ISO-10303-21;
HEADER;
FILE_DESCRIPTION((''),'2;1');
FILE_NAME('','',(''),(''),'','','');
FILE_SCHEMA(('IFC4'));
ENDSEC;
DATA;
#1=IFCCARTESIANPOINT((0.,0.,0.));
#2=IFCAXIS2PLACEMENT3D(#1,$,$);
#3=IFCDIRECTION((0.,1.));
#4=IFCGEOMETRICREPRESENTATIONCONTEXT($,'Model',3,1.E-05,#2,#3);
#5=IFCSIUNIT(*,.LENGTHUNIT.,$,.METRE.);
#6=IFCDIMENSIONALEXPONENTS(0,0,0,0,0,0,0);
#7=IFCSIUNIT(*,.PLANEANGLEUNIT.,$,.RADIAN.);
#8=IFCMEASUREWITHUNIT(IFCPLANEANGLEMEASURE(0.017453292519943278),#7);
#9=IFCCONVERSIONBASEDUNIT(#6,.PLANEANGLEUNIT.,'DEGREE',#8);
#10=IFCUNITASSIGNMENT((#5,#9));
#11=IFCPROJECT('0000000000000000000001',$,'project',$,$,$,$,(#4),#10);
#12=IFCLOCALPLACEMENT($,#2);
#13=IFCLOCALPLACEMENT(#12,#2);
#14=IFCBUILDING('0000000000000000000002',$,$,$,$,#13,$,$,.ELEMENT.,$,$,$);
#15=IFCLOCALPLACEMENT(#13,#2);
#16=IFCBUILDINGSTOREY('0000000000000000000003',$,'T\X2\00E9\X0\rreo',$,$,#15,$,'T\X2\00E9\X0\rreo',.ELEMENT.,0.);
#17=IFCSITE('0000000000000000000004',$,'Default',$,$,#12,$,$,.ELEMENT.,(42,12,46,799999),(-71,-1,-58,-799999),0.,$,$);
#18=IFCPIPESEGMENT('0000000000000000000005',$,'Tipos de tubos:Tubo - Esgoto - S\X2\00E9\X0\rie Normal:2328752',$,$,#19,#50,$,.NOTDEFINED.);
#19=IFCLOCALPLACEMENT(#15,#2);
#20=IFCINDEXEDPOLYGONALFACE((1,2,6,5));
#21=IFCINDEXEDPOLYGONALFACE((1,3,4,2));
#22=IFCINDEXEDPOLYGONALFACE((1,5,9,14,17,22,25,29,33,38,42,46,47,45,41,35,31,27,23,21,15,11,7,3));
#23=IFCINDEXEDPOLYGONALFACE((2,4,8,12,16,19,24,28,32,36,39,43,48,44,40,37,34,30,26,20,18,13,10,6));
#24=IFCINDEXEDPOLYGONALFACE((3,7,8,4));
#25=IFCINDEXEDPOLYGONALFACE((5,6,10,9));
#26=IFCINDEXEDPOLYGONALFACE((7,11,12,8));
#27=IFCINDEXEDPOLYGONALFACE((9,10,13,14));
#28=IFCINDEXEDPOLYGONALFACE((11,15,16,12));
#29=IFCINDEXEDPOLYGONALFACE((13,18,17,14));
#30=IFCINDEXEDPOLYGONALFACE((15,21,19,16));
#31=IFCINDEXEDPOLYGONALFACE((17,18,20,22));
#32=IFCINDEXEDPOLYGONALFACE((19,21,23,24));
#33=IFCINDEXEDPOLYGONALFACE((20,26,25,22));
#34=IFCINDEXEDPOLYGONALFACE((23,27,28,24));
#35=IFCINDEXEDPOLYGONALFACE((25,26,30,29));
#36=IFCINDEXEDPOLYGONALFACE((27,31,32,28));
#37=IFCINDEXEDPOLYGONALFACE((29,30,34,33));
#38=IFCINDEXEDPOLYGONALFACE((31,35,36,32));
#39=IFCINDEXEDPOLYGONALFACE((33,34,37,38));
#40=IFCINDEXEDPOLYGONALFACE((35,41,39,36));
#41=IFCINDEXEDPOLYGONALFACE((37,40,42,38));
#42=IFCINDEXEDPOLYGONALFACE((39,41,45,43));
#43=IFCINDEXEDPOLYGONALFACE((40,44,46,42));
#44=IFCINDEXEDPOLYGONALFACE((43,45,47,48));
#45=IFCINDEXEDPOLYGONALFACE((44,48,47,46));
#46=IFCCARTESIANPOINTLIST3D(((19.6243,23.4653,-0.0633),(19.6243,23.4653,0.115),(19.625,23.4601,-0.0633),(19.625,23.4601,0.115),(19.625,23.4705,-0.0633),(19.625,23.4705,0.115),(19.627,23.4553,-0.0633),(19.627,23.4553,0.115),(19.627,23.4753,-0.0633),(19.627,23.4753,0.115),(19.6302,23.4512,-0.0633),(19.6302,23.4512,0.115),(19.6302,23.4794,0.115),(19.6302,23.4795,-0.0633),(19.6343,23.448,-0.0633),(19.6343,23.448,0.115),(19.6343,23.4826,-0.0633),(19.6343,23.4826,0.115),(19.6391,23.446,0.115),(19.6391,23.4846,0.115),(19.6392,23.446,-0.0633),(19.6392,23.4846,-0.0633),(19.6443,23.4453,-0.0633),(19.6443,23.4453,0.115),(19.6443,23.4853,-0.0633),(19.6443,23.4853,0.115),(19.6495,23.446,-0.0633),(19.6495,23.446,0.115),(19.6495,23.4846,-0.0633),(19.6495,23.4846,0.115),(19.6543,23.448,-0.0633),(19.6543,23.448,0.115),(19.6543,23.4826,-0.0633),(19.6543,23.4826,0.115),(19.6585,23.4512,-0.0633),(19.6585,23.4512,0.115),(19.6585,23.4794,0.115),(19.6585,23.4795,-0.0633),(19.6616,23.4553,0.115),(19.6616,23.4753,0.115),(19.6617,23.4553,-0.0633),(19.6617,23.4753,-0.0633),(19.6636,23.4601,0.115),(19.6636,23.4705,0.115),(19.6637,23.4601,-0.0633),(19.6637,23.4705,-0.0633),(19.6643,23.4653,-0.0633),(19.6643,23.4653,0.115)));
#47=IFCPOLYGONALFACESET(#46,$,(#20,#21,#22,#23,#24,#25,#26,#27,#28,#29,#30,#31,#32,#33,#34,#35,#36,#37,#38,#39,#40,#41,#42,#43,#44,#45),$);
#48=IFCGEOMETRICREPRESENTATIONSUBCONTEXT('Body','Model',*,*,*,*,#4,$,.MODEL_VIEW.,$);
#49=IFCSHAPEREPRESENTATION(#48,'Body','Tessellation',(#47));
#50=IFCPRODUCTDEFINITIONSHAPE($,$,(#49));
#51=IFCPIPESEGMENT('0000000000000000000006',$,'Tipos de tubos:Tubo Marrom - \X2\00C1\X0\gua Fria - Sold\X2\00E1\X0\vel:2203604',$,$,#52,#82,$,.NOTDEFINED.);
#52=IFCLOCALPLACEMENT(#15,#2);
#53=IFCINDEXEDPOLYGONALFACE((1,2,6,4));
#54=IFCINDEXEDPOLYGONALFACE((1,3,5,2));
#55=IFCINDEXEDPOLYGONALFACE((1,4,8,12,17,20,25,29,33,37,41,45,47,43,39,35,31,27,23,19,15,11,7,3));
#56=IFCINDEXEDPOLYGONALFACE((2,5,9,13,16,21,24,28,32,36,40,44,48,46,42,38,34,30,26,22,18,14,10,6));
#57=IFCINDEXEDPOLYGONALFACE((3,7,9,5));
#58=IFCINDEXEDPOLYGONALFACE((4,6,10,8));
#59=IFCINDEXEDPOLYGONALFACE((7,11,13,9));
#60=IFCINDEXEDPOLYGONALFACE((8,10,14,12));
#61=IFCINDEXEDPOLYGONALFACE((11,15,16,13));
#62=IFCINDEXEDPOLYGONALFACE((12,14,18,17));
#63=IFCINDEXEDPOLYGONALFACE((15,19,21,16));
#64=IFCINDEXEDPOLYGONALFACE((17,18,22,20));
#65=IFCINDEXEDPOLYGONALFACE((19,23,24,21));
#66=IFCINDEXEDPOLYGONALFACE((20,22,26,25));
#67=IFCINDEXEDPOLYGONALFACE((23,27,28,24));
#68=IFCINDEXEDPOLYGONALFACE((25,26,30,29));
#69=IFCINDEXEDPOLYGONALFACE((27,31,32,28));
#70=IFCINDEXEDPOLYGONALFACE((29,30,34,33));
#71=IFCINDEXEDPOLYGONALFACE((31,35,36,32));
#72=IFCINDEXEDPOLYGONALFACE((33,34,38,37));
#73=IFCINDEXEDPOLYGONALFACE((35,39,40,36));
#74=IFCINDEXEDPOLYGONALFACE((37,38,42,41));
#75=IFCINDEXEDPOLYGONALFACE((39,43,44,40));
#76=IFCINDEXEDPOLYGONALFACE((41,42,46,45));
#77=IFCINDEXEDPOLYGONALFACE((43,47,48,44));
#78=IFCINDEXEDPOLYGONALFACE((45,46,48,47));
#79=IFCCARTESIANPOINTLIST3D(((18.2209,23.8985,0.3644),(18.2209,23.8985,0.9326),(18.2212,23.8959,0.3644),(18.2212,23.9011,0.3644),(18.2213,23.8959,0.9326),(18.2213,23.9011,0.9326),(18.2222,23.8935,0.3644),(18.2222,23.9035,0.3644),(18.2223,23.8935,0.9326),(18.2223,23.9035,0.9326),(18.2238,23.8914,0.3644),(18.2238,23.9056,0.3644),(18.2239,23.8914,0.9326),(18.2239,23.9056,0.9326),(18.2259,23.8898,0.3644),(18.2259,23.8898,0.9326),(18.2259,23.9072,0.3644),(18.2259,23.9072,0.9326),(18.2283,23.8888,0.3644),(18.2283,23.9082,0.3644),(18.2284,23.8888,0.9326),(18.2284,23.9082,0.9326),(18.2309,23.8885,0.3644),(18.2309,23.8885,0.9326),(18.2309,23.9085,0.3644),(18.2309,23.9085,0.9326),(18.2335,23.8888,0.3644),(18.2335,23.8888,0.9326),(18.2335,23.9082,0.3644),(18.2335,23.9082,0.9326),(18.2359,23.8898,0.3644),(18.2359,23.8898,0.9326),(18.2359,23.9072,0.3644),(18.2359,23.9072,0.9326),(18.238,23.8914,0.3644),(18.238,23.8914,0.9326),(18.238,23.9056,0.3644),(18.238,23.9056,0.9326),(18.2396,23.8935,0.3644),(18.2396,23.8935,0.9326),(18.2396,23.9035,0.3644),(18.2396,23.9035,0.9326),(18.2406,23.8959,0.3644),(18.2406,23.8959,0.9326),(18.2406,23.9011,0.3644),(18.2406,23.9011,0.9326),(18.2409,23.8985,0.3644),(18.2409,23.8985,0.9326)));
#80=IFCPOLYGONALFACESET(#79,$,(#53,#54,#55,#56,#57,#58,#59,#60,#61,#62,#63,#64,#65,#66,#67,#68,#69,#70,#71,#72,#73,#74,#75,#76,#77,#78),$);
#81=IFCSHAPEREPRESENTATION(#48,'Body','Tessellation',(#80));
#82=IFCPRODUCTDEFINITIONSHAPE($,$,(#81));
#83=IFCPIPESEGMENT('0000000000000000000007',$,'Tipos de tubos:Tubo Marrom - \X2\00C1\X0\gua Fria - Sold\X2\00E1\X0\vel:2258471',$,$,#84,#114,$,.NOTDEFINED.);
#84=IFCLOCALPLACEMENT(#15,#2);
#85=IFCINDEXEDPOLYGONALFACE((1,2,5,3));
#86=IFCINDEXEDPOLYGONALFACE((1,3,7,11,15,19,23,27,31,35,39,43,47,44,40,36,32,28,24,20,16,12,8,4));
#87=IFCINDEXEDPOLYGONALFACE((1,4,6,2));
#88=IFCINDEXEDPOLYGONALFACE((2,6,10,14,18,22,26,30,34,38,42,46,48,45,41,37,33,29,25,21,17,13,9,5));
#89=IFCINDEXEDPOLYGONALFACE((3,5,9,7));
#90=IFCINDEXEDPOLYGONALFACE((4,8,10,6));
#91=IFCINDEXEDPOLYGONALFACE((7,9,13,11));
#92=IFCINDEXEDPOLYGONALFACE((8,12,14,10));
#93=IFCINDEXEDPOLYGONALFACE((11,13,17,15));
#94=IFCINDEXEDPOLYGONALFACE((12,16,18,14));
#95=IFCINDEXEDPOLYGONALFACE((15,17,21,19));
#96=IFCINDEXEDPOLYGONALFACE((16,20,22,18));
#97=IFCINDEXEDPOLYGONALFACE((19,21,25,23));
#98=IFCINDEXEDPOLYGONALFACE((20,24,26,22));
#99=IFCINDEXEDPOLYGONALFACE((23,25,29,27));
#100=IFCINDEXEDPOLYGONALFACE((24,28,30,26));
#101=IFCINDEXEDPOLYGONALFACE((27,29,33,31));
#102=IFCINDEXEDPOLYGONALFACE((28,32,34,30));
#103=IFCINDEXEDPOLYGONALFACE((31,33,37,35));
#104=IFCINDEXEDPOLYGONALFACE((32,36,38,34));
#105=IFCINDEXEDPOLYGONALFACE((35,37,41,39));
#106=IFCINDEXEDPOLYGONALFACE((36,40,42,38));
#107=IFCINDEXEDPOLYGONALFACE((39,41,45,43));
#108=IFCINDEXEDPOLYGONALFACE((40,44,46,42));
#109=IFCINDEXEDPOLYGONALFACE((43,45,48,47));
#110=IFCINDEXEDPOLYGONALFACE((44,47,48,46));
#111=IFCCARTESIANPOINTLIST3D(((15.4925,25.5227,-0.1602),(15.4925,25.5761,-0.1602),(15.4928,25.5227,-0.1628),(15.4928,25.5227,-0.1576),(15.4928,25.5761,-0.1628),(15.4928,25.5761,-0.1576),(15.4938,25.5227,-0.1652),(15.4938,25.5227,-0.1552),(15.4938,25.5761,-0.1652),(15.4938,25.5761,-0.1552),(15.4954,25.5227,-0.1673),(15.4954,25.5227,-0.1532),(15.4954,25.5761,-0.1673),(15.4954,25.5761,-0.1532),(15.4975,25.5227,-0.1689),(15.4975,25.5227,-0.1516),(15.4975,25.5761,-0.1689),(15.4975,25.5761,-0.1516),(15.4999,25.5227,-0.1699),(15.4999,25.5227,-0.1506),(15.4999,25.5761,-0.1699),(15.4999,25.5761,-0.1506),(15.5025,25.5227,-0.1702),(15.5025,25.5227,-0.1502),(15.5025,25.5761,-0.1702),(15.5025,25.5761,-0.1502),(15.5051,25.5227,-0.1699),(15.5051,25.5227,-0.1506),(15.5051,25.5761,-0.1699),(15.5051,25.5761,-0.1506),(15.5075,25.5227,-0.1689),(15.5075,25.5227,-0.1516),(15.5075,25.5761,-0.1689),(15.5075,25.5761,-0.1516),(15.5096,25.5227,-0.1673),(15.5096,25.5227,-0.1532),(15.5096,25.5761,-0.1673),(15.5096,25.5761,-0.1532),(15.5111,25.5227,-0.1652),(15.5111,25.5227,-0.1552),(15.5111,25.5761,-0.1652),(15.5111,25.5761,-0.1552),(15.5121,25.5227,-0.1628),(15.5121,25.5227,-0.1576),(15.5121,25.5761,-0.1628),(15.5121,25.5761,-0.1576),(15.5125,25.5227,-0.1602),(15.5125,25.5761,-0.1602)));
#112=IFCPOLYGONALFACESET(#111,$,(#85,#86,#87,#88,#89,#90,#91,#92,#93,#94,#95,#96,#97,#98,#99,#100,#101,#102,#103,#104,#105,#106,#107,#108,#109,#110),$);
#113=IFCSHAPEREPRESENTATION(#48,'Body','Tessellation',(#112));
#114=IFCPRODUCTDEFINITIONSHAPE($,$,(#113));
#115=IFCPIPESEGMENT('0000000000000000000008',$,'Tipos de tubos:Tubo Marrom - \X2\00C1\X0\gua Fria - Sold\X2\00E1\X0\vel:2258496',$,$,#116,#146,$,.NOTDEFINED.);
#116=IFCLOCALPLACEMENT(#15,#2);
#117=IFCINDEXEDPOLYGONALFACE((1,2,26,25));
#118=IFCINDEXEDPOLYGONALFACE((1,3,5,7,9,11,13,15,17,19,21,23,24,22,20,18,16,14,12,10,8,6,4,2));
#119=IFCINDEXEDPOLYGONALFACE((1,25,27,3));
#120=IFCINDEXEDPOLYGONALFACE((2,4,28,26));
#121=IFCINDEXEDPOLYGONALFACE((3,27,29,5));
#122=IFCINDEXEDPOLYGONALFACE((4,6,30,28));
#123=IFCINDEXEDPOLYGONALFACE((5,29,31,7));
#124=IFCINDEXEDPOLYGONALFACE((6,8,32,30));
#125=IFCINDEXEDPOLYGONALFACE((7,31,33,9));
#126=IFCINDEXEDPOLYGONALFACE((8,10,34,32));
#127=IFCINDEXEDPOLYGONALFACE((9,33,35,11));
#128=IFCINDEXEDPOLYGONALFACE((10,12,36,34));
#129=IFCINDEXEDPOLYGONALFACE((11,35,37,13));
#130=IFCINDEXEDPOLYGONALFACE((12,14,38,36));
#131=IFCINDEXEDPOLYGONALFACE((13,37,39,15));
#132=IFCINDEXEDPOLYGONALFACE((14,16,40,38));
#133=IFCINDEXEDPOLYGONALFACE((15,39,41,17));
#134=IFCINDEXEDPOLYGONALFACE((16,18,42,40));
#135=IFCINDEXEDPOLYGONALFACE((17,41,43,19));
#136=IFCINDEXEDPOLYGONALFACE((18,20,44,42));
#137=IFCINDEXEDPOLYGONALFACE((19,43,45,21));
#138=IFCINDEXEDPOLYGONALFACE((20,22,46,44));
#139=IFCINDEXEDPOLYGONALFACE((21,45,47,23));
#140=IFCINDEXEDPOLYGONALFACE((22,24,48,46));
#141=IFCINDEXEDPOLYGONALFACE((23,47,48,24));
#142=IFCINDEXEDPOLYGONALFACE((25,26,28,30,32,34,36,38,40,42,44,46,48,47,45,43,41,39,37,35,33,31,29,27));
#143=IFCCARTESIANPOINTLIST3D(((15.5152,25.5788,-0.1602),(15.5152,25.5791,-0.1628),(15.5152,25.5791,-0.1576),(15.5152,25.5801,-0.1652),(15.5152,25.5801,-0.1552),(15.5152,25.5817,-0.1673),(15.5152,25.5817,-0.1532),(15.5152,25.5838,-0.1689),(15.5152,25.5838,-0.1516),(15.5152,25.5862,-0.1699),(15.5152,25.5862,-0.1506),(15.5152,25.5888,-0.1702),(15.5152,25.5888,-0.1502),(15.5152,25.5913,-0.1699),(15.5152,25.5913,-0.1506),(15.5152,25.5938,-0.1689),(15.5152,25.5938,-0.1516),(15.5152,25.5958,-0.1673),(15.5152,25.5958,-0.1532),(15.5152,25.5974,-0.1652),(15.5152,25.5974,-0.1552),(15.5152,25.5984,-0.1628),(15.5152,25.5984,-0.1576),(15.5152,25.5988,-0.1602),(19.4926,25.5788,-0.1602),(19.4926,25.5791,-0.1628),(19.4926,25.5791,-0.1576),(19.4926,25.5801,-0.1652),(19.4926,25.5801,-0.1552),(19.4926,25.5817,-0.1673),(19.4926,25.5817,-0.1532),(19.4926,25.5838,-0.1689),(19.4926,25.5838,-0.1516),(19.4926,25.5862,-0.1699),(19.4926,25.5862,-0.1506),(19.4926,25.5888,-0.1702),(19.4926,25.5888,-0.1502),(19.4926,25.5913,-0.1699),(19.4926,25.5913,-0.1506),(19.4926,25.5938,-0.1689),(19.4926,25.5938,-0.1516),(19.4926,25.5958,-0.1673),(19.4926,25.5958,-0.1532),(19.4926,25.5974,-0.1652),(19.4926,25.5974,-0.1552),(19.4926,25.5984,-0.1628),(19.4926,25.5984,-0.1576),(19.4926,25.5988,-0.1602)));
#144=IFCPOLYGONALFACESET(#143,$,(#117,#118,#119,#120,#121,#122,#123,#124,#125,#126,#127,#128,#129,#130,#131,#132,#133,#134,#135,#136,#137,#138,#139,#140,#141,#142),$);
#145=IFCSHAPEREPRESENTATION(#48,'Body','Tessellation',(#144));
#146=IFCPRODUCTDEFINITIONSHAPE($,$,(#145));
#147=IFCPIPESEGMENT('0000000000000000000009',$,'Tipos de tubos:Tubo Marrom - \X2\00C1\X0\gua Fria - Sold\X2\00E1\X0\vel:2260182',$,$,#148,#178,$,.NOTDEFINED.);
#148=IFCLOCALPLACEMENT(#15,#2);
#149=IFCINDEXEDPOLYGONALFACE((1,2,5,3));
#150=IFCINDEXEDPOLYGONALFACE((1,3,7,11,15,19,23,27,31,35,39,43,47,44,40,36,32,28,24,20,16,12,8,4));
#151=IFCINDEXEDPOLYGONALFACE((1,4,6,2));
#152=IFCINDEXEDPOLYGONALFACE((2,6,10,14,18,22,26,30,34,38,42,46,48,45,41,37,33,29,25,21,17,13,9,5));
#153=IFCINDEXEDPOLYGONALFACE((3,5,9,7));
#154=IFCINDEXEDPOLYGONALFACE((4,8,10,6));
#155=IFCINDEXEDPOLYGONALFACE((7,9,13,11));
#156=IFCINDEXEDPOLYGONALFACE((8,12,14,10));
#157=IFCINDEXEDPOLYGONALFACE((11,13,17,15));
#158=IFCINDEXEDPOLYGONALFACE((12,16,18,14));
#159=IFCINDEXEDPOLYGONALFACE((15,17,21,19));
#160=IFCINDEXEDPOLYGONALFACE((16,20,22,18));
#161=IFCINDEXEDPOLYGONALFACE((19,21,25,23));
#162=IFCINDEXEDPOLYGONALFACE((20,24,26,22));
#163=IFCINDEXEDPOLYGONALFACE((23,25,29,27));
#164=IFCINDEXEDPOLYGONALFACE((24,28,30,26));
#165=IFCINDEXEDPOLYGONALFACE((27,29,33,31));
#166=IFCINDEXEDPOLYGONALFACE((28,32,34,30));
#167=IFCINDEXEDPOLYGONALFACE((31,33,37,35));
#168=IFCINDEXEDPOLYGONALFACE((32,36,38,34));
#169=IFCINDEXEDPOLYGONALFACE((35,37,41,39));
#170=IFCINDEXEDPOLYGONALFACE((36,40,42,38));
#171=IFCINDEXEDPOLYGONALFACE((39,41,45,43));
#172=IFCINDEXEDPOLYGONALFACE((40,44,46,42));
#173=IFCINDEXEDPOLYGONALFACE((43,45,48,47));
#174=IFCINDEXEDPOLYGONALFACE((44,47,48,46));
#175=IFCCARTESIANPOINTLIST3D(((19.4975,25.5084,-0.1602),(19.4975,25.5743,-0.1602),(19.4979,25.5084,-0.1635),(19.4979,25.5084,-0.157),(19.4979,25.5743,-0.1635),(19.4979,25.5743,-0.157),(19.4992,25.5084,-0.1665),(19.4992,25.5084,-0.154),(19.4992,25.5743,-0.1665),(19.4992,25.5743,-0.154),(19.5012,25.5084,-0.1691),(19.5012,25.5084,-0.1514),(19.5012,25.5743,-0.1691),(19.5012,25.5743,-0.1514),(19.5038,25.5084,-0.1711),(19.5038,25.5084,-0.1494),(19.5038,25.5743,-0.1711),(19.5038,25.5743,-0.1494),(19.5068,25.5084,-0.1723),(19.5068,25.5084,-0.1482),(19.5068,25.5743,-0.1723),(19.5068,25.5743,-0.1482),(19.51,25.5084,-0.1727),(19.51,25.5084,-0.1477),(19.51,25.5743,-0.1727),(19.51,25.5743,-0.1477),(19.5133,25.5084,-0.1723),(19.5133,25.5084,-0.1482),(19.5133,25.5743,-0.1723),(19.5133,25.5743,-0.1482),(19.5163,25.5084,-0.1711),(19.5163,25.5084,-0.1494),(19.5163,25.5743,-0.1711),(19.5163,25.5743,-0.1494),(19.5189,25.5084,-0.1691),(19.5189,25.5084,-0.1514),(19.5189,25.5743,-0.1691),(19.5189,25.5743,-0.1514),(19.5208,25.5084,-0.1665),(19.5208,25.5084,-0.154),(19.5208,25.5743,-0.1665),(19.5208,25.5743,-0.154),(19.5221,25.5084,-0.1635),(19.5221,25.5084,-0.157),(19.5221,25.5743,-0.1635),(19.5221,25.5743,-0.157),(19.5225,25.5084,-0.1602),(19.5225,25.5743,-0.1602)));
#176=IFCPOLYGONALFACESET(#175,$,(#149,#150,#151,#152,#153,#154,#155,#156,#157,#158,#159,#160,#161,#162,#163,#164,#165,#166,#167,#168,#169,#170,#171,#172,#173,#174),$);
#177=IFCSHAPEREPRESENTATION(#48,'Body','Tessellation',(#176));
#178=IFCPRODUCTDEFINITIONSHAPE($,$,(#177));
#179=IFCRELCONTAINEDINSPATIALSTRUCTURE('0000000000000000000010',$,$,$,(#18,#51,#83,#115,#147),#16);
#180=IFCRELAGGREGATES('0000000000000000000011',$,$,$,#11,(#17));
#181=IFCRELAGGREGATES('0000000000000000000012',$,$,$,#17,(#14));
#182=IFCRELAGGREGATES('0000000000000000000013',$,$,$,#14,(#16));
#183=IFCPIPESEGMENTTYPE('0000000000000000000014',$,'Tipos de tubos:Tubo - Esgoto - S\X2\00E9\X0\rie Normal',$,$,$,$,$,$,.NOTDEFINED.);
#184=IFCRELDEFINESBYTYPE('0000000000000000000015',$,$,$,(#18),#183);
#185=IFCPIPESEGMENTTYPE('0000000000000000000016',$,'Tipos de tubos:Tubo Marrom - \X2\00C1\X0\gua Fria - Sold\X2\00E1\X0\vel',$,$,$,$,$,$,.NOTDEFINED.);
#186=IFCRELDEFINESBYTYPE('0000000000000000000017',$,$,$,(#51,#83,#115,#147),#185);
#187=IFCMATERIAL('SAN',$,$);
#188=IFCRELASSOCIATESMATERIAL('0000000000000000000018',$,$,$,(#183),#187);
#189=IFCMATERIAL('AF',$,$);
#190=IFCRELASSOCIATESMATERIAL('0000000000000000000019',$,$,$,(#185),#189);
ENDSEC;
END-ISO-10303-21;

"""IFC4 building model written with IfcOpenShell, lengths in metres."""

from ifc_helpers import new_model, entity, si_unit, converted_unit, direction, frame, origin, place, context, subcontext, project, spatial, arc, indexed_curve, outline, extrude, material, type_object, element, save


model = new_model("IFC4")

# Units and contexts
model_context = context("Model", 3, precision=1e-05, world=origin(), true_north=direction((0.0, 1.0)))
body_context = subcontext(model_context, "Body", "Model", "MODEL_VIEW")
ifc_project = project(units=[si_unit("LENGTHUNIT", "METRE"), converted_unit("PLANEANGLEUNIT", "DEGREE", entity("IfcPlaneAngleMeasure", 0.017453292519943278), si_unit("PLANEANGLEUNIT", "RADIAN"), dimensions=[0, 0, 0, 0, 0, 0, 0])], contexts=[model_context])

# Site, building, storey
site_placement = place(None, origin())
site = spatial("IfcSite", under=ifc_project, at=site_placement, Name="Default", CompositionType="ELEMENT", RefLatitude=(42, 12, 46, 799999), RefLongitude=(-71, -1, -58, -799999), RefElevation=0.0)
building_placement = place(site_placement, origin())
building = spatial("IfcBuilding", under=site, at=building_placement, CompositionType="ELEMENT")
storey_placement = place(building_placement, origin())
storey = spatial("IfcBuildingStorey", under=building, at=storey_placement, Name="Térreo", LongName="Térreo", CompositionType="ELEMENT", Elevation=0.0)

# Pipe segments
ifc_material_1 = material(Name="SAN")
pipe_segment_type_1 = type_object("IfcPipeSegmentType", Name="Tipos de tubos:Tubo - Esgoto - Série Normal", PredefinedType="NOTDEFINED", material=ifc_material_1)
pipe_segment_1_placement = place(storey_placement, origin())
element("IfcPipeSegment", 1, at=pipe_segment_1_placement, inside=storey, type_object=pipe_segment_type_1, Name="Tipos de tubos:Tubo - Esgoto - Série Normal:2328752", PredefinedType="NOTDEFINED", context=body_context, shape_type="SweptSolid", body=[
    extrude(outline(indexed_curve([(0.02, 0.0), (0.0141, 0.0141), (0.0, 0.02), (-0.0141, 0.0141), (-0.02, 0.0), (-0.0141, -0.0141), (0.0, -0.02), (0.0141, -0.0141)], segments=[arc(1, 2, 3), arc(3, 4, 5), arc(5, 6, 7), arc(7, 8, 1)], self_intersect=False)), frame((19.6443, 23.4653, -0.0633), z_axis=(-0.000045, -0.000093, 1.0), x_axis=(1.0, 0.0, 0.000045)), (0.0, 0.0, 1.0), 0.1783),
])
ifc_material_2 = material(Name="AF")
pipe_segment_type_2 = type_object("IfcPipeSegmentType", Name="Tipos de tubos:Tubo Marrom - Água Fria - Soldável", PredefinedType="NOTDEFINED", material=ifc_material_2)
pipe_segment_2_placement = place(storey_placement, origin())
element("IfcPipeSegment", 2, at=pipe_segment_2_placement, inside=storey, type_object=pipe_segment_type_2, Name="Tipos de tubos:Tubo Marrom - Água Fria - Soldável:2203604", PredefinedType="NOTDEFINED", context=body_context, shape_type="SweptSolid", body=[
    extrude(outline(indexed_curve([(0.01, 0.0), (0.0071, 0.0071), (0.0, 0.01), (-0.0071, 0.0071), (-0.01, 0.0), (-0.0071, -0.0071), (0.0, -0.01), (0.0071, -0.0071)], segments=[arc(1, 2, 3), arc(3, 4, 5), arc(5, 6, 7), arc(7, 8, 1)], self_intersect=False)), frame((18.2309, 23.8985, 0.3644), z_axis=(0.000081, 0.0, 1.0), x_axis=(1.0, 0.0, -0.000081)), (0.0, 0.0, 1.0), 0.5682),
])
pipe_segment_3_placement = place(storey_placement, origin())
element("IfcPipeSegment", 3, at=pipe_segment_3_placement, inside=storey, type_object=pipe_segment_type_2, Name="Tipos de tubos:Tubo Marrom - Água Fria - Soldável:2258471", PredefinedType="NOTDEFINED", context=body_context, shape_type="SweptSolid", body=[
    extrude(outline(indexed_curve([(0.01, 0.0), (0.0071, 0.0071), (0.0, 0.01), (-0.0071, 0.0071), (-0.01, 0.0), (-0.0071, -0.0071), (0.0, -0.01), (0.0071, -0.0071)], segments=[arc(1, 2, 3), arc(3, 4, 5), arc(5, 6, 7), arc(7, 8, 1)], self_intersect=False)), frame((15.5025, 25.5227, -0.1602), z_axis=(0.0, 1.0, 0.0), x_axis=(1.0, 0.0, 0.0)), (0.0, 0.0, 1.0), 0.0534),
])
pipe_segment_4_placement = place(storey_placement, origin())
element("IfcPipeSegment", 4, at=pipe_segment_4_placement, inside=storey, type_object=pipe_segment_type_2, Name="Tipos de tubos:Tubo Marrom - Água Fria - Soldável:2258496", PredefinedType="NOTDEFINED", context=body_context, shape_type="SweptSolid", body=[
    extrude(outline(indexed_curve([(0.01, 0.0), (0.0071, 0.0071), (0.0, 0.01), (-0.0071, 0.0071), (-0.01, 0.0), (-0.0071, -0.0071), (0.0, -0.01), (0.0071, -0.0071)], segments=[arc(1, 2, 3), arc(3, 4, 5), arc(5, 6, 7), arc(7, 8, 1)], self_intersect=False)), frame((15.5152, 25.5888, -0.1602), z_axis=(1.0, 0.0, 0.0), x_axis=(0.0, -1.0, 0.0)), (0.0, 0.0, 1.0), 3.9774),
])
pipe_segment_5_placement = place(storey_placement, origin())
element("IfcPipeSegment", 5, at=pipe_segment_5_placement, inside=storey, type_object=pipe_segment_type_2, Name="Tipos de tubos:Tubo Marrom - Água Fria - Soldável:2260182", PredefinedType="NOTDEFINED", context=body_context, shape_type="SweptSolid", body=[
    extrude(outline(indexed_curve([(0.0125, 0.0), (0.0088, 0.0088), (0.0, 0.0125), (-0.0088, 0.0088), (-0.0125, 0.0), (-0.0088, -0.0088), (0.0, -0.0125), (0.0088, -0.0088)], segments=[arc(1, 2, 3), arc(3, 4, 5), arc(5, 6, 7), arc(7, 8, 1)], self_intersect=False)), frame((19.51, 25.5084, -0.1602), z_axis=(0.0, 1.0, 0.0), x_axis=(-1.0, 0.0, 0.0)), (0.0, 0.0, 1.0), 0.0658),
])

save(model, "model.ifc")
